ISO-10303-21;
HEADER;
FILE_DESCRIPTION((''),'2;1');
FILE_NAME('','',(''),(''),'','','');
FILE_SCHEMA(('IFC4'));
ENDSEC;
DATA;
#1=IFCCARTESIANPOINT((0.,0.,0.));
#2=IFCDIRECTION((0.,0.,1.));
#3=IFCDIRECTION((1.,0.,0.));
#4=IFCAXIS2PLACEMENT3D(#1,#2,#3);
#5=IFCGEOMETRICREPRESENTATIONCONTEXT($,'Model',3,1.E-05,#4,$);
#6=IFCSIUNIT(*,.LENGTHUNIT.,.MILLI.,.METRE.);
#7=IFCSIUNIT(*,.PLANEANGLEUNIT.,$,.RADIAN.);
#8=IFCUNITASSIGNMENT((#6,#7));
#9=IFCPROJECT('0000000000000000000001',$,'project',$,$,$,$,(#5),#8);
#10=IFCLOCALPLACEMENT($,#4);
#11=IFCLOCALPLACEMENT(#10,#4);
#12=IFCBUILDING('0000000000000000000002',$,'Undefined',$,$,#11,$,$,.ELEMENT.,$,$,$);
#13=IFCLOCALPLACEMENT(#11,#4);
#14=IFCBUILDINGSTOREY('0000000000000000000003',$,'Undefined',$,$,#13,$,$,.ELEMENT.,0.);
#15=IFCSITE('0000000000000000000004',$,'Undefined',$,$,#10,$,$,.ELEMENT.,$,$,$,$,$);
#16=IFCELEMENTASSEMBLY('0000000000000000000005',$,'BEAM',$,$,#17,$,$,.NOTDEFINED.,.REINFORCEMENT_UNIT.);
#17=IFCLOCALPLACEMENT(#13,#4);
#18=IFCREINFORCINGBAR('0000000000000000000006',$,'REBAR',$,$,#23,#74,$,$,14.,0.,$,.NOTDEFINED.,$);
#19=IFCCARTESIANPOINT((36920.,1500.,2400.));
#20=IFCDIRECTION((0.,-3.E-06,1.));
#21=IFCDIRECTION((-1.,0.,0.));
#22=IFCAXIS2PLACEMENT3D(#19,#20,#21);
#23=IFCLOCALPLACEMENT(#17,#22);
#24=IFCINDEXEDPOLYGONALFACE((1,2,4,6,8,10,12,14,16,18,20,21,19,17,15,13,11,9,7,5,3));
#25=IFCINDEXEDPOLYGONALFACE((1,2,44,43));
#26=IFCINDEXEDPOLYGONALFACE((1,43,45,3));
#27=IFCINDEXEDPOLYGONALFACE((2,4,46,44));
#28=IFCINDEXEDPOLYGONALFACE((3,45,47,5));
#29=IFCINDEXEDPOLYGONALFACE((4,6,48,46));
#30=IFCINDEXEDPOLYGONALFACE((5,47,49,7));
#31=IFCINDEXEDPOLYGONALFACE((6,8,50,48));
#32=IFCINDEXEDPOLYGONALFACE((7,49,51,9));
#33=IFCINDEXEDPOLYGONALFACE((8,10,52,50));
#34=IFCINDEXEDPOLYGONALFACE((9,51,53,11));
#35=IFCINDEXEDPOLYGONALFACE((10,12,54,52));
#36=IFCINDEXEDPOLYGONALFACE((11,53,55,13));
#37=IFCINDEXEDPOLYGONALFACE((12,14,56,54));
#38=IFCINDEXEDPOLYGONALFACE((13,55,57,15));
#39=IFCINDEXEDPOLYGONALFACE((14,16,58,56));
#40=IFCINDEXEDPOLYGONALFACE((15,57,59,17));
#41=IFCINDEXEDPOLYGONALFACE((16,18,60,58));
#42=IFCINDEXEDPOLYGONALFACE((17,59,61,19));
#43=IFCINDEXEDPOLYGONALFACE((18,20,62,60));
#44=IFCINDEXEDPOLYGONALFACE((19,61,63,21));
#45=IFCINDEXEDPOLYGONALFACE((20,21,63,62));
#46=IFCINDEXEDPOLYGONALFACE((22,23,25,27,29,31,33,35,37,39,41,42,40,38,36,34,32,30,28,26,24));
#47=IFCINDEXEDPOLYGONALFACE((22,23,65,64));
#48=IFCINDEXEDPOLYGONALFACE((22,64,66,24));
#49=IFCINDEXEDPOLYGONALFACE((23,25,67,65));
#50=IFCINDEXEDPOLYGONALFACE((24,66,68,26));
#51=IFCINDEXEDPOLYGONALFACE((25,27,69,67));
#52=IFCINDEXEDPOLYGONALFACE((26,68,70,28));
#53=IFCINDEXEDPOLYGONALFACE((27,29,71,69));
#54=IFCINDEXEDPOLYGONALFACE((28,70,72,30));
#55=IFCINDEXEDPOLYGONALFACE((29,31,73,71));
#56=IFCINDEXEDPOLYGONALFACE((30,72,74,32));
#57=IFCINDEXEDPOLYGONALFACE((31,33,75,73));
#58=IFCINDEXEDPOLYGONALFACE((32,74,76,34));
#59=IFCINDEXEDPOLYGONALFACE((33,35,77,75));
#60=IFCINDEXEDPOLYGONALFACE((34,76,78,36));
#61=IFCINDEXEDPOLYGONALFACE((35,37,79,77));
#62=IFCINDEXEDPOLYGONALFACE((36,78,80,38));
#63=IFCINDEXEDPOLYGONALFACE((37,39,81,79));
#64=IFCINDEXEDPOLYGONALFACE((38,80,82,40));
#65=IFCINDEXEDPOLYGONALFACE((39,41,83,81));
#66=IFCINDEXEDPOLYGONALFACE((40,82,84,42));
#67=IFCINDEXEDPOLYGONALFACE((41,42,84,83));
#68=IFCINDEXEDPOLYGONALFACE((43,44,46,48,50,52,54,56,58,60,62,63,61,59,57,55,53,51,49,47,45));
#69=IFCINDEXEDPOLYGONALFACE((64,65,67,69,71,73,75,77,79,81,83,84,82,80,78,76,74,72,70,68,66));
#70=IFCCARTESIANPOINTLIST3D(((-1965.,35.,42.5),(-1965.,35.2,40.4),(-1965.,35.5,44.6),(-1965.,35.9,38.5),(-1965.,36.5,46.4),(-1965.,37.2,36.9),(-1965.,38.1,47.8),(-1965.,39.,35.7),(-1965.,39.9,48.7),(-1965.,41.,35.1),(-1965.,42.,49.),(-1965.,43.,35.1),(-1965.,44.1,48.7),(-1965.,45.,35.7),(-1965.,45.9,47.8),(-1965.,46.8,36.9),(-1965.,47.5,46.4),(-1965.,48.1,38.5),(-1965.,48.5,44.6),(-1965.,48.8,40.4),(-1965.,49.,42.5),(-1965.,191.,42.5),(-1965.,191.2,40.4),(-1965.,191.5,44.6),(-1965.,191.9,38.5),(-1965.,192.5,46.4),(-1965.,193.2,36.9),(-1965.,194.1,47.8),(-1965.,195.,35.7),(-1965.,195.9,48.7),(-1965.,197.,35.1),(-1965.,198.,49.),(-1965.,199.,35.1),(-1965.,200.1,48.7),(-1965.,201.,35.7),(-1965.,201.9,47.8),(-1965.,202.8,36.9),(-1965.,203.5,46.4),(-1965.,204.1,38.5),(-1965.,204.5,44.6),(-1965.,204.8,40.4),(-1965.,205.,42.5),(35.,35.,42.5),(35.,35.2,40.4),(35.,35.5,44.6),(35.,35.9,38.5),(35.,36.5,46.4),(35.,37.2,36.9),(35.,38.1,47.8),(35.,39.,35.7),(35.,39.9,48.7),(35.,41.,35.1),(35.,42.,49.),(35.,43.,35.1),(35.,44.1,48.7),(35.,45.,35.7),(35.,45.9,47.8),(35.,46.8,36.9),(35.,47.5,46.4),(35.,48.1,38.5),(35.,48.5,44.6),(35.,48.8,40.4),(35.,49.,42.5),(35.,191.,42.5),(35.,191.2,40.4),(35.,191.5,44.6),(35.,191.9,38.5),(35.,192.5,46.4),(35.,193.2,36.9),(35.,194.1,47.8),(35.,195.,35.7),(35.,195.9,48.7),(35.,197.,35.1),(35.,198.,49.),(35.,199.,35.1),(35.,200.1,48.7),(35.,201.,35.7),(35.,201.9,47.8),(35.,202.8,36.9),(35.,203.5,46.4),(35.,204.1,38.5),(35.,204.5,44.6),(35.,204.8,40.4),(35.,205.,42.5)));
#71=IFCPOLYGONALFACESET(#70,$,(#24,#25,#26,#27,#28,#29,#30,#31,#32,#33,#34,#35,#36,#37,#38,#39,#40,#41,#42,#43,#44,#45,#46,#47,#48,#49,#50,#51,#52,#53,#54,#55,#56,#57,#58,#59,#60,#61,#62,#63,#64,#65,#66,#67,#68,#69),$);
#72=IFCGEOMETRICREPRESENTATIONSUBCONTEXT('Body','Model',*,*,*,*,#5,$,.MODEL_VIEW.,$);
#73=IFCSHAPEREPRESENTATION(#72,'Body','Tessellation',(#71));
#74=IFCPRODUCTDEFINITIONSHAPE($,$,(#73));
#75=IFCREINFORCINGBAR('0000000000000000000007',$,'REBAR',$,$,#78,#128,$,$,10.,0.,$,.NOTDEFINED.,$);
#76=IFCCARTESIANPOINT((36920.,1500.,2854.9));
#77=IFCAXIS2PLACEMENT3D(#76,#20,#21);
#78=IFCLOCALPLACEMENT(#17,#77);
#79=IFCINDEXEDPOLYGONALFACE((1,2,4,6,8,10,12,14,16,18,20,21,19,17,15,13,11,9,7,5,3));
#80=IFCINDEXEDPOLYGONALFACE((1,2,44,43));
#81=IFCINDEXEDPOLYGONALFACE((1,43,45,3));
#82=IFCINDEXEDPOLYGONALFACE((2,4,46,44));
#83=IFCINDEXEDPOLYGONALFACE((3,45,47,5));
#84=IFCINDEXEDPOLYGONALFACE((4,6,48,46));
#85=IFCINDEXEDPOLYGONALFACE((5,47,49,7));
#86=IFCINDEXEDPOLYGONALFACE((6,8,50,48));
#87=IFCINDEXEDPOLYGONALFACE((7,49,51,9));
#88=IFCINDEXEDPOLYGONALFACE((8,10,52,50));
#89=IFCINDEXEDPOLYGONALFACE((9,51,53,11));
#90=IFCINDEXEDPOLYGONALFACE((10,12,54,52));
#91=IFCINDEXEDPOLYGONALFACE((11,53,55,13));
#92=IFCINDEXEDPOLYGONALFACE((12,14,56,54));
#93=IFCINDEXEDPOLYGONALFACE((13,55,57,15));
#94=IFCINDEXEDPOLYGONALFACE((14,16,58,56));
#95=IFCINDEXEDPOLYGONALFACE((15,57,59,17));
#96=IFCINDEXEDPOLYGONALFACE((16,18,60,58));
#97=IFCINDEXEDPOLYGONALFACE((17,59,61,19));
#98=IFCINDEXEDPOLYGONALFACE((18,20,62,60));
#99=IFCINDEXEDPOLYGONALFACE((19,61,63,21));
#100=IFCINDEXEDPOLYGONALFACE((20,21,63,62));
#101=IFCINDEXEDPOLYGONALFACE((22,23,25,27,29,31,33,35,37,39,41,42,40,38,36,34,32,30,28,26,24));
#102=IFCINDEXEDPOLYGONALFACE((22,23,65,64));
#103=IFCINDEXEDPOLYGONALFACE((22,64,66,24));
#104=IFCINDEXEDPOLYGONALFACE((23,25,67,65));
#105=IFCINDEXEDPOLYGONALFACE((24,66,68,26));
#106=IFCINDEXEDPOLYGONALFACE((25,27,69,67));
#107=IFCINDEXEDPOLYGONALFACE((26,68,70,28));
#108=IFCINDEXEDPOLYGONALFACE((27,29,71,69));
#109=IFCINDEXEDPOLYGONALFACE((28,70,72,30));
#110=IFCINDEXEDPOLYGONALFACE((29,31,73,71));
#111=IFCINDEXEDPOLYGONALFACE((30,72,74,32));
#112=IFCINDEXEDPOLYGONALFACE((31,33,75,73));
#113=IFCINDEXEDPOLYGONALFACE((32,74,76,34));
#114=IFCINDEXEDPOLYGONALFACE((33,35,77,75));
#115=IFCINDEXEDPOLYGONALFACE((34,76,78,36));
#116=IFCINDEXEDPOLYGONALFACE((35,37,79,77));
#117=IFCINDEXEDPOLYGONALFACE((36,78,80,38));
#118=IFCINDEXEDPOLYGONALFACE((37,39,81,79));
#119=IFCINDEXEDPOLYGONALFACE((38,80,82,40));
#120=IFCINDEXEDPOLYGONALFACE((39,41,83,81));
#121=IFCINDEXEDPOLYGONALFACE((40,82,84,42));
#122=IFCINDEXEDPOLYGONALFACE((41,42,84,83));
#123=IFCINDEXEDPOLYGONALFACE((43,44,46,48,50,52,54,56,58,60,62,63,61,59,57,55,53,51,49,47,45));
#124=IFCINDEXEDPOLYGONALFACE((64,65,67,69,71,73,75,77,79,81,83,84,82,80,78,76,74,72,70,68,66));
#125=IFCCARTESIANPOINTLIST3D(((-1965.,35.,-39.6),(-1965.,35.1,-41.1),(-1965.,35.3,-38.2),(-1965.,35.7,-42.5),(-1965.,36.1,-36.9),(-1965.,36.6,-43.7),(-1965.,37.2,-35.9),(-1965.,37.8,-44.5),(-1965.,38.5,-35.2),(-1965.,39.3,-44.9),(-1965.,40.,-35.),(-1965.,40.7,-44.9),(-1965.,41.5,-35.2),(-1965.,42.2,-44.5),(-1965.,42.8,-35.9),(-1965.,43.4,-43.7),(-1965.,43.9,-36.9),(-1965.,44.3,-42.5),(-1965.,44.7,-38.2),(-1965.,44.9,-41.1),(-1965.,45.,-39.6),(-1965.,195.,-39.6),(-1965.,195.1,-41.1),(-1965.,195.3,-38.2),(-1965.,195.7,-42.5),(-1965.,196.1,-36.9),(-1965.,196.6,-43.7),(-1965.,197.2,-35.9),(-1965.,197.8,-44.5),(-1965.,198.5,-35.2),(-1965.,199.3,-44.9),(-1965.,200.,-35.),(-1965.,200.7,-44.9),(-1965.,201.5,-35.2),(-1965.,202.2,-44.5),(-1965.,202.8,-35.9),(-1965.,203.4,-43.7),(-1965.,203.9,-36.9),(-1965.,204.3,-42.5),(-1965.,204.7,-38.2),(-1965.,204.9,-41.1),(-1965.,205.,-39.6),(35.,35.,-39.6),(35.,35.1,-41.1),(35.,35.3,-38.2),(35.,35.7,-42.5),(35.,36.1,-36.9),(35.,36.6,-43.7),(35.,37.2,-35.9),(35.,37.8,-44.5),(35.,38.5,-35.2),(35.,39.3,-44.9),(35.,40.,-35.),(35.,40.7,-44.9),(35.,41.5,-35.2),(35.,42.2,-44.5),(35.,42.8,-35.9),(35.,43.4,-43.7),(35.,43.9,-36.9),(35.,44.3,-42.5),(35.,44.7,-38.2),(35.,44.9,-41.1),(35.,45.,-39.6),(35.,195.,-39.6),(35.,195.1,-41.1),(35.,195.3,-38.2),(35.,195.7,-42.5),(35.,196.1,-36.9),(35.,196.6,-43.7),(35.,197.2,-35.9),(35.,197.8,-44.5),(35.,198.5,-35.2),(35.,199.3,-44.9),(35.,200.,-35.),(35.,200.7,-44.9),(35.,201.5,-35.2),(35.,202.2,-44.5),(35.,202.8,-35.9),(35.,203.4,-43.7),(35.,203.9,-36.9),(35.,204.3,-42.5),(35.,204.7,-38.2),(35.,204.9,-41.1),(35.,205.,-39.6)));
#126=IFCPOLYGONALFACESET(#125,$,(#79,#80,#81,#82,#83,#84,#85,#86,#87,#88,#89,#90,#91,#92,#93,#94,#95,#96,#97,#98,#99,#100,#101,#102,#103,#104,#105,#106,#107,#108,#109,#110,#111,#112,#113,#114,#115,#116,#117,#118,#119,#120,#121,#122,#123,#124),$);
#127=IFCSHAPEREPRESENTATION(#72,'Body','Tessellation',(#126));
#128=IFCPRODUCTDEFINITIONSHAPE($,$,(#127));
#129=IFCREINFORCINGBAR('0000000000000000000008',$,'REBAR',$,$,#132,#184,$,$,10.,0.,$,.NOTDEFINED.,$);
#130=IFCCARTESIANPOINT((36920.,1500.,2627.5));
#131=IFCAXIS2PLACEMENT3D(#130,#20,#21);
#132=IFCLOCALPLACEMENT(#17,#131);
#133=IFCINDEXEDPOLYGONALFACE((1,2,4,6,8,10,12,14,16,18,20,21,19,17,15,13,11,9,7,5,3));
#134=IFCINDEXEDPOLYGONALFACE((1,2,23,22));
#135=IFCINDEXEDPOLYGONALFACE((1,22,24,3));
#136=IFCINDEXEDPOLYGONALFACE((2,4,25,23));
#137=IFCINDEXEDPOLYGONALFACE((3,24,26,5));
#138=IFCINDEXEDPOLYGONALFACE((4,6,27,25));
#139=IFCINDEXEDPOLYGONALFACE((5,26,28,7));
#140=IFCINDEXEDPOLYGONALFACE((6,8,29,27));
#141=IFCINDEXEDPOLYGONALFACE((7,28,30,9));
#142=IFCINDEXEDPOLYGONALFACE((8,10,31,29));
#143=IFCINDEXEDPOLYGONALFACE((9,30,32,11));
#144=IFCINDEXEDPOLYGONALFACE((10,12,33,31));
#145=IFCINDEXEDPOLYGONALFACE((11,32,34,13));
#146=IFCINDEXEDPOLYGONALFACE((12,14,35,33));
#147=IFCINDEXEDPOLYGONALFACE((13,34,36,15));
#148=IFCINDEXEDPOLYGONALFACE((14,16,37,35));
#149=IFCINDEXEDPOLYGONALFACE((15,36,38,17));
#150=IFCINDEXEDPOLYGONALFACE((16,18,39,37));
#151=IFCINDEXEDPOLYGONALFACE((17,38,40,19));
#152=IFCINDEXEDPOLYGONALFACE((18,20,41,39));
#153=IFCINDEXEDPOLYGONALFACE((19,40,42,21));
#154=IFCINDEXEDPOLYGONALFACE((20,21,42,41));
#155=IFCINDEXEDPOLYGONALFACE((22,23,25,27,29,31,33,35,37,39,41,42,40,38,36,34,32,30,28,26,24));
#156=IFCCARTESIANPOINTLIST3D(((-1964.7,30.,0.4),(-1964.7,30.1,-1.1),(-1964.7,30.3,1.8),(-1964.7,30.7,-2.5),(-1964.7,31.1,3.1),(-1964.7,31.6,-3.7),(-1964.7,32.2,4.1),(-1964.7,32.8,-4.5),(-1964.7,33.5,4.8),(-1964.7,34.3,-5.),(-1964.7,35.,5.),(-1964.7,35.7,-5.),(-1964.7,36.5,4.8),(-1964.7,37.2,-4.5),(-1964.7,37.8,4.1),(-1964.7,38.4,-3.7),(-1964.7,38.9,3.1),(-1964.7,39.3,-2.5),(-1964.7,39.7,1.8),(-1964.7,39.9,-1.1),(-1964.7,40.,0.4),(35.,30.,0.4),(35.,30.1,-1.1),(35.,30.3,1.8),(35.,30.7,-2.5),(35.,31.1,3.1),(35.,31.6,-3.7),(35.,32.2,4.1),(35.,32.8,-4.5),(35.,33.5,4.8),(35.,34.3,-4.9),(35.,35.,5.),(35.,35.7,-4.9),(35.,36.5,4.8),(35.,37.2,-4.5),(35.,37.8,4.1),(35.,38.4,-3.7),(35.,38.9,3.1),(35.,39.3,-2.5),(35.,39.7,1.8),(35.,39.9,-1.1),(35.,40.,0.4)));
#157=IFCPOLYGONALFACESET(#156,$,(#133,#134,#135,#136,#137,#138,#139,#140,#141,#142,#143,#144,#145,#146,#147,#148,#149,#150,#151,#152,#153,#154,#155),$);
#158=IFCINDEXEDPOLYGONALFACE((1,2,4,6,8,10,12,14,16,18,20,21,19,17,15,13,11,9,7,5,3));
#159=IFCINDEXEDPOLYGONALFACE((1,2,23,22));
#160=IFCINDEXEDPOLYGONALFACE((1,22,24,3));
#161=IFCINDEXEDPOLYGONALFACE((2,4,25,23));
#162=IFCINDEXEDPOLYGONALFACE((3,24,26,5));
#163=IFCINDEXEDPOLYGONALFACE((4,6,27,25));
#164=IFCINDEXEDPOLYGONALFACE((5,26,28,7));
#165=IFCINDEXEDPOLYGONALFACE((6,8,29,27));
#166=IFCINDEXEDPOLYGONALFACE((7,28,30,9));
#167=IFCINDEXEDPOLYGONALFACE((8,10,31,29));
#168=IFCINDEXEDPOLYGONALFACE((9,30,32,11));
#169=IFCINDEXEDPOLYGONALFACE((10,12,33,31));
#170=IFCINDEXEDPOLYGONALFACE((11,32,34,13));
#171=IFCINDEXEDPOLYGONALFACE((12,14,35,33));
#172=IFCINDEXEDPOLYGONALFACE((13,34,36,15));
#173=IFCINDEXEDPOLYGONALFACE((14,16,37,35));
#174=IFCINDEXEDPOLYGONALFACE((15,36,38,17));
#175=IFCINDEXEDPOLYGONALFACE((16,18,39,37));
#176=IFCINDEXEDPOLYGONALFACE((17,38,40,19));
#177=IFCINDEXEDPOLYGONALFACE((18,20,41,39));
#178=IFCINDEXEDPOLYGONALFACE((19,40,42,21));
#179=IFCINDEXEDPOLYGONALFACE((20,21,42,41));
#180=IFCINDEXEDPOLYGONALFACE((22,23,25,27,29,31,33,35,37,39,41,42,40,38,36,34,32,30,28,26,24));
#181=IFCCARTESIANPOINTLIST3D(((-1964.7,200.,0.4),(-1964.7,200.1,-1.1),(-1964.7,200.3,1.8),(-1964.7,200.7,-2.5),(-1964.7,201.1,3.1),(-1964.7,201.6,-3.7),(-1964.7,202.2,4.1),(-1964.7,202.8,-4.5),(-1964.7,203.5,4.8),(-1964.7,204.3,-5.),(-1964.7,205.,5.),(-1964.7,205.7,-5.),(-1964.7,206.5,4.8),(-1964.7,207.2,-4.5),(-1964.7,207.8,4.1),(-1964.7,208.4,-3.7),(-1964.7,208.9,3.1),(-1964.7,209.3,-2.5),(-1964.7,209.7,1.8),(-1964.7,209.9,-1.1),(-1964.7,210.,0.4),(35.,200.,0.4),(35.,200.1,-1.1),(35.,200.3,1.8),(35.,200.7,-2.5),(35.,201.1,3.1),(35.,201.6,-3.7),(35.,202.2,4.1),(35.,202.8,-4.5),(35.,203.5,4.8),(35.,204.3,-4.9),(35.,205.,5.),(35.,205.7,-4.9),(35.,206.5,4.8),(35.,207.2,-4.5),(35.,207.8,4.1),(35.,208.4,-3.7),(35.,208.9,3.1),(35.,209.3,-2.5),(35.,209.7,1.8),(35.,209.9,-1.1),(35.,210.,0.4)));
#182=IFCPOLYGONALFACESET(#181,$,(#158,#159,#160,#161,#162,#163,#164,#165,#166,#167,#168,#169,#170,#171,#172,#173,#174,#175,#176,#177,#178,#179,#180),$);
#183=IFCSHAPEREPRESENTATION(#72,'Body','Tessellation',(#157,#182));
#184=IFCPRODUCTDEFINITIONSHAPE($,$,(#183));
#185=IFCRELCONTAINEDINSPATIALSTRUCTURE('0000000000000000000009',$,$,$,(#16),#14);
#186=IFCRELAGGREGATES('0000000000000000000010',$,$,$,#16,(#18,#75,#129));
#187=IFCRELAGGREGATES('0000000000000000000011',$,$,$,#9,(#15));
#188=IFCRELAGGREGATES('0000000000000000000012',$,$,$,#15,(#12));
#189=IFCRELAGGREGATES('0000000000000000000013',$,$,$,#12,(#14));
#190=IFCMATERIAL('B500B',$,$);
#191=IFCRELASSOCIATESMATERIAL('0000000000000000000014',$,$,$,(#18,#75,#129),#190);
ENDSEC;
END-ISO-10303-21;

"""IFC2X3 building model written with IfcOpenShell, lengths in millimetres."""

from ifc_helpers import new_model, entity, si_unit, frame, origin_with_axes, place, context, subcontext, project, spatial, source, transform, mapped, material, element, aggregate, save


model = new_model("IFC2X3")

# Units and contexts
model_context = context("Model", 3, precision=1e-05, world=origin_with_axes())
body_context = subcontext(model_context, "Body", "Model", "MODEL_VIEW")
ifc_project = project(units=[si_unit("LENGTHUNIT", "METRE", prefix="MILLI"), si_unit("PLANEANGLEUNIT", "RADIAN")], contexts=[model_context])

# Site, building, storey
site_placement = place(None, origin_with_axes())
site = spatial("IfcSite", under=ifc_project, at=site_placement, Name="Undefined", CompositionType="ELEMENT")
building_placement = place(site_placement, origin_with_axes())
building = spatial("IfcBuilding", under=site, at=building_placement, Name="Undefined", CompositionType="ELEMENT")
storey_placement = place(building_placement, origin_with_axes())
storey = spatial("IfcBuildingStorey", under=building, at=storey_placement, Name="Undefined", CompositionType="ELEMENT", Elevation=0.0)

# Element assembly
assembly_1_placement = place(storey_placement, origin_with_axes())
assembly_1 = element("IfcElementAssembly", 1, at=assembly_1_placement, inside=storey, Name="BEAM", AssemblyPlace="NOTDEFINED", PredefinedType="REINFORCEMENT_UNIT")

# Shared definitions
ifc_material_1 = material(Name="B500B")

# Reinforcing bars
shared_shape_1 = source(origin_with_axes(), body_context, "Body", "AdvancedSweptSolid", [
    entity("IfcSweptDiskSolid", entity("IfcTrimmedCurve", entity("IfcLine", entity("IfcCartesianPoint", [0.0, 0.0, 0.0]), entity("IfcVector", entity("IfcDirection", [1.0, 0.0, 0.0]), 1.0)), [entity("IfcParameterValue", 0.0)], [entity("IfcParameterValue", 1999.999614)], True, "PARAMETER"), 7.0, None, 0.0, 2000.0),
])
shared_shape_2 = source(origin_with_axes(), body_context, "Body", "AdvancedSweptSolid", [
    entity("IfcSweptDiskSolid", entity("IfcTrimmedCurve", entity("IfcLine", entity("IfcCartesianPoint", [0.0, 0.0, 0.0]), entity("IfcVector", entity("IfcDirection", [1.0, 0.0, 0.0]), 1.0)), [entity("IfcParameterValue", 0.0)], [entity("IfcParameterValue", 1999.999614)], True, "PARAMETER"), 7.0, None, 0.0, 2000.0),
])
reinforcing_bar_1_placement = place(assembly_1_placement, frame((36920.0, 1500.0, 2400.0), z_axis=(0.0, -0.000003, 1.0), x_axis=(-1.0, 0.0, 0.0)))
reinforcing_bar_1 = element("IfcReinforcingBar", 2, at=reinforcing_bar_1_placement, material=ifc_material_1, Name="REBAR", BarRole="NOTDEFINED", CrossSectionArea=0.0, NominalDiameter=14.0, context=body_context, shape_type="MappedRepresentation", body=[
    mapped(shared_shape_1, transform((-1965.0, 42.0, 42.0))),
    mapped(shared_shape_2, transform((-1965.0, 198.0, 42.0))),
])
shared_shape_3 = source(origin_with_axes(), body_context, "Body", "AdvancedSweptSolid", [
    entity("IfcSweptDiskSolid", entity("IfcTrimmedCurve", entity("IfcLine", entity("IfcCartesianPoint", [0.0, 0.0, 0.0]), entity("IfcVector", entity("IfcDirection", [1.0, 0.0, 0.0]), 1.0)), [entity("IfcParameterValue", 0.0)], [entity("IfcParameterValue", 1999.999614)], True, "PARAMETER"), 5.0, None, 0.0, 2000.0),
])
shared_shape_4 = source(origin_with_axes(), body_context, "Body", "AdvancedSweptSolid", [
    entity("IfcSweptDiskSolid", entity("IfcTrimmedCurve", entity("IfcLine", entity("IfcCartesianPoint", [0.0, 0.0, 0.0]), entity("IfcVector", entity("IfcDirection", [1.0, 0.0, 0.0]), 1.0)), [entity("IfcParameterValue", 0.0)], [entity("IfcParameterValue", 1999.999614)], True, "PARAMETER"), 5.0, None, 0.0, 2000.0),
])
reinforcing_bar_2_placement = place(assembly_1_placement, frame((36920.0, 1500.0, 2854.9), z_axis=(0.0, -0.000003, 1.0), x_axis=(-1.0, 0.0, 0.0)))
reinforcing_bar_2 = element("IfcReinforcingBar", 3, at=reinforcing_bar_2_placement, material=ifc_material_1, Name="REBAR", BarRole="NOTDEFINED", CrossSectionArea=0.0, NominalDiameter=10.0, context=body_context, shape_type="MappedRepresentation", body=[
    mapped(shared_shape_3, transform((-1965.0, 40.0, -40.0))),
    mapped(shared_shape_4, transform((-1965.0, 200.0, -40.0))),
])
shared_shape_5 = source(origin_with_axes(), body_context, "Body", "AdvancedSweptSolid", [
    entity("IfcSweptDiskSolid", entity("IfcTrimmedCurve", entity("IfcLine", entity("IfcCartesianPoint", [0.0, 0.0, 0.0]), entity("IfcVector", entity("IfcDirection", [1.0, 0.0, 0.000005]), 1.0)), [entity("IfcParameterValue", 0.0)], [entity("IfcParameterValue", 1999.779614)], True, "PARAMETER"), 5.0, None, 0.0, 1999.8),
])
shared_shape_6 = source(origin_with_axes(), body_context, "Body", "AdvancedSweptSolid", [
    entity("IfcSweptDiskSolid", entity("IfcTrimmedCurve", entity("IfcLine", entity("IfcCartesianPoint", [0.0, 0.0, 0.0]), entity("IfcVector", entity("IfcDirection", [1.0, 0.0, 0.000005]), 1.0)), [entity("IfcParameterValue", 0.0)], [entity("IfcParameterValue", 1999.779614)], True, "PARAMETER"), 5.0, None, 0.0, 1999.8),
])
reinforcing_bar_3_placement = place(assembly_1_placement, frame((36920.0, 1500.0, 2627.5), z_axis=(0.0, -0.000003, 1.0), x_axis=(-1.0, 0.0, 0.0)))
reinforcing_bar_3 = element("IfcReinforcingBar", 4, at=reinforcing_bar_3_placement, material=ifc_material_1, Name="REBAR", BarRole="NOTDEFINED", CrossSectionArea=0.0, NominalDiameter=10.0, context=body_context, shape_type="MappedRepresentation", body=[
    mapped(shared_shape_5, transform((-1964.7, 35.0, 0.0))),
    mapped(shared_shape_6, transform((-1964.7, 205.0, 0.0))),
])
aggregate(assembly_1, [reinforcing_bar_1, reinforcing_bar_2, reinforcing_bar_3])

save(model, "model.ifc")
